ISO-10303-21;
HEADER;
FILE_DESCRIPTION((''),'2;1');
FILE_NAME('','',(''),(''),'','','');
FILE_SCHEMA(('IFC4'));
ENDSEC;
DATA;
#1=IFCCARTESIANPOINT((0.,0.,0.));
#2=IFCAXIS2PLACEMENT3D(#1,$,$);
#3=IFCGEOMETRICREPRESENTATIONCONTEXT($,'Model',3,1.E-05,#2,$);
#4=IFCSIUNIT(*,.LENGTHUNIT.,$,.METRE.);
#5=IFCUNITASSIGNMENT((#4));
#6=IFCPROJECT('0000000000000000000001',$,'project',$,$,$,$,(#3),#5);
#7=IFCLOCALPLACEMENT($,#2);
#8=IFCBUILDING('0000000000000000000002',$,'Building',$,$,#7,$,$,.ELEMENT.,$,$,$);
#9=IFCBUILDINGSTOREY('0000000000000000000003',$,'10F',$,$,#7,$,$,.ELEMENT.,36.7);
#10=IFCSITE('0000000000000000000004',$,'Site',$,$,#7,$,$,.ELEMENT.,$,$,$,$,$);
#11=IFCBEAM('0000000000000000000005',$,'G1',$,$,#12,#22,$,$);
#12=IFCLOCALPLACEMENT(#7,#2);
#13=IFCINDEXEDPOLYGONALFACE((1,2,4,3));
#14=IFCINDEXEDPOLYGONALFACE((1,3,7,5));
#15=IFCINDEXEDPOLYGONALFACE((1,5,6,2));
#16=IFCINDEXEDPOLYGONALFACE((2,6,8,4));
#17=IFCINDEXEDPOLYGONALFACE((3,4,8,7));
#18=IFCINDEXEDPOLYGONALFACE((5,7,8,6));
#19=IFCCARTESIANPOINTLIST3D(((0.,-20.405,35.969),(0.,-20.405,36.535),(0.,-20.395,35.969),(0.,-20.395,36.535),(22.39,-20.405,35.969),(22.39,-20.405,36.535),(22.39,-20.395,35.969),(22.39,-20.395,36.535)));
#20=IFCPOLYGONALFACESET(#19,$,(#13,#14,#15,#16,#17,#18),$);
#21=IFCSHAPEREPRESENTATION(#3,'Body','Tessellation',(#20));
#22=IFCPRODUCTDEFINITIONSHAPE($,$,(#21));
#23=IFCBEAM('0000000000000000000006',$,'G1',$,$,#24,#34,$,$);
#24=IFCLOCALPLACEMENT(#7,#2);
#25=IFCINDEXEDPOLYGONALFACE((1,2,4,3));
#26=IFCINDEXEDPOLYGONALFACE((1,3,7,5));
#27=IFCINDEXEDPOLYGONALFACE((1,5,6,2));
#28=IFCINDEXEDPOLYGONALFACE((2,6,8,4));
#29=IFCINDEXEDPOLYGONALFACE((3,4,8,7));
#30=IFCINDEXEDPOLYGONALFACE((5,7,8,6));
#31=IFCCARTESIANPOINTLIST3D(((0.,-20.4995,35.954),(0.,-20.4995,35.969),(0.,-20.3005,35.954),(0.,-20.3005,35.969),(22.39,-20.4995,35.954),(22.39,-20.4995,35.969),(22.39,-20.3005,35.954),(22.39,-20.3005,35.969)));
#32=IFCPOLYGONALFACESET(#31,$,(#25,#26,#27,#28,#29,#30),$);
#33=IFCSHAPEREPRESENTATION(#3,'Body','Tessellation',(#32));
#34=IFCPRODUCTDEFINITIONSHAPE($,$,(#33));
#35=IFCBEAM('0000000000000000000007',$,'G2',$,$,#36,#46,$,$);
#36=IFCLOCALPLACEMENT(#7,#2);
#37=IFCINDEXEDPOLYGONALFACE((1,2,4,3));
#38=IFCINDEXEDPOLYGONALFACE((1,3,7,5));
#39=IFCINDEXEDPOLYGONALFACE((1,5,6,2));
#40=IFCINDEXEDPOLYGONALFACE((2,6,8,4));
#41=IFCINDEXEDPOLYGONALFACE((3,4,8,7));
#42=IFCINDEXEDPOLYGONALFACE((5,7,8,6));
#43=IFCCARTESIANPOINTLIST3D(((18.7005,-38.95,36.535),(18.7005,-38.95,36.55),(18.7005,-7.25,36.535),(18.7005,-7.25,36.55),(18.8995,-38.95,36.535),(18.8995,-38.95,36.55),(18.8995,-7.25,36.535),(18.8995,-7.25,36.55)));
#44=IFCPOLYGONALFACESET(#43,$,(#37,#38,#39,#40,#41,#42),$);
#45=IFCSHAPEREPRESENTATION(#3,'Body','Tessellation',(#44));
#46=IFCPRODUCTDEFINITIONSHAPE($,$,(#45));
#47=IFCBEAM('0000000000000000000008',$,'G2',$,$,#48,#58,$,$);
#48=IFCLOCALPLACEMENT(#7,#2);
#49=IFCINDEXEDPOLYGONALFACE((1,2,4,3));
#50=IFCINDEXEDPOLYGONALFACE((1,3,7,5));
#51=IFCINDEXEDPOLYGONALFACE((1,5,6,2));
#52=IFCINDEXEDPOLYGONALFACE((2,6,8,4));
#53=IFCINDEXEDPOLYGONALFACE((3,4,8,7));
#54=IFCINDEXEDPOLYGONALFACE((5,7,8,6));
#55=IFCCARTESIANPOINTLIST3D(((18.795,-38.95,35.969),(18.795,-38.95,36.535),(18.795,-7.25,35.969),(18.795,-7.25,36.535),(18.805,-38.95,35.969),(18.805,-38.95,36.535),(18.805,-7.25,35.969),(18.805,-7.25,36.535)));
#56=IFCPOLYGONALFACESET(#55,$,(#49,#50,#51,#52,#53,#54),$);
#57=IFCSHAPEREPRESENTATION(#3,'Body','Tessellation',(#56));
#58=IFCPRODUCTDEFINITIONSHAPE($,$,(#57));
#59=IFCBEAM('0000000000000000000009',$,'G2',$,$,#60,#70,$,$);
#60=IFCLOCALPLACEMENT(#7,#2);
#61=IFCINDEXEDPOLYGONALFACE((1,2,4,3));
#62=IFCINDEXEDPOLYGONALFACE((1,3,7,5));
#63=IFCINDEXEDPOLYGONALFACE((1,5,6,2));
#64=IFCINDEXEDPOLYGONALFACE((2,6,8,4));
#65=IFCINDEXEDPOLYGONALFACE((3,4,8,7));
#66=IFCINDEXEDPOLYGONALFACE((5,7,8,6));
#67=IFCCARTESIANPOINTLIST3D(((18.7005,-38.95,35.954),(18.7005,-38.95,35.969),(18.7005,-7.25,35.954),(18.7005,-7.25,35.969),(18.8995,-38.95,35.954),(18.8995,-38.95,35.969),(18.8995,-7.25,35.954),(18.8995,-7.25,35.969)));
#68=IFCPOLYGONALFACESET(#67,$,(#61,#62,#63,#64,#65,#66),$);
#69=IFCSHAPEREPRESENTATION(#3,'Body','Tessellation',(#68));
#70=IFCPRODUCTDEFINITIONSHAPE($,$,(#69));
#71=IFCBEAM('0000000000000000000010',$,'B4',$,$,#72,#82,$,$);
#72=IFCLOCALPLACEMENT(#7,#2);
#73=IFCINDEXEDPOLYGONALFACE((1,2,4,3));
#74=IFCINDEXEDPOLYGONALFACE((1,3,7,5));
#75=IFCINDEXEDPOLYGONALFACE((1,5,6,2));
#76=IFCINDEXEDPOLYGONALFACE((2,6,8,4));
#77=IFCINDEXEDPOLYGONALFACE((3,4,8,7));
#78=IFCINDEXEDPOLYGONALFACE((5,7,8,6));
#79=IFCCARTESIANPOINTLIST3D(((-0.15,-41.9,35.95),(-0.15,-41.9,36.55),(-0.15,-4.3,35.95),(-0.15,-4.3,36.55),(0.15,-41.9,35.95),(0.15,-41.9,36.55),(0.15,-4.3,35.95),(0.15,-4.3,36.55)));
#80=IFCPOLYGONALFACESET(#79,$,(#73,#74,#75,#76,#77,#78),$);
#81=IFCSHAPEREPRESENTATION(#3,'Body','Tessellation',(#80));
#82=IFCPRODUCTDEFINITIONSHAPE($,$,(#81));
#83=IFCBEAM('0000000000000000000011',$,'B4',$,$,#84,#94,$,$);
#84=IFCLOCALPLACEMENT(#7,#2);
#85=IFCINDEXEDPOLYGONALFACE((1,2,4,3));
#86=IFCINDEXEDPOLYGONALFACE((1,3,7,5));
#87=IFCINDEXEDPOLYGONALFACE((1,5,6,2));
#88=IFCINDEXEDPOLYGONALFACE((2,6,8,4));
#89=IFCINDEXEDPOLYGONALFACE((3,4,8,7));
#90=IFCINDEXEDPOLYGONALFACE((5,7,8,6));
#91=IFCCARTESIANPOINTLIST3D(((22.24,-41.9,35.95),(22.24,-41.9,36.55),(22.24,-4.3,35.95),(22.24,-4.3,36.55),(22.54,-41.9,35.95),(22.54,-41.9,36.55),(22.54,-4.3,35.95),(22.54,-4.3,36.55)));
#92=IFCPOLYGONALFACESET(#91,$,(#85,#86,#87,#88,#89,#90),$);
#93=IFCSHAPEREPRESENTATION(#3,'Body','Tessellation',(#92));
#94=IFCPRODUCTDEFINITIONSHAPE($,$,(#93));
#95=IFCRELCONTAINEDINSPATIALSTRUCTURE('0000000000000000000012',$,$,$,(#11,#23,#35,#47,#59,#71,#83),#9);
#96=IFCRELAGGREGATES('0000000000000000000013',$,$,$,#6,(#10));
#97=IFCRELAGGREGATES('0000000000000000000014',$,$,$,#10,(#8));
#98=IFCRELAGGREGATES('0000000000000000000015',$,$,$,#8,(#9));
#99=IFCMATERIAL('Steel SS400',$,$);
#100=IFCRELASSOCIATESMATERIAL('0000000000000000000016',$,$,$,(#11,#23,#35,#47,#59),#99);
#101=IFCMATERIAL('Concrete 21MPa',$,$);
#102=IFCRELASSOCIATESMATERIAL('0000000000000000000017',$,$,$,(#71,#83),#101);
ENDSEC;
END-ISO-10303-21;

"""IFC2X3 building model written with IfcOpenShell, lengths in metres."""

from ifc_helpers import new_model, si_unit, frame, origin, origin_2d, place, context, project, spatial, rectangle, extrude, material, element, save


model = new_model("IFC2X3")

# Units and contexts
model_context = context("Model", 3, precision=1e-05, world=origin())
ifc_project = project(units=[si_unit("LENGTHUNIT", "METRE")], contexts=[model_context])

# Site, building, storey
placement = place(None, origin())
site = spatial("IfcSite", under=ifc_project, at=placement, Name="Site", CompositionType="ELEMENT")
building = spatial("IfcBuilding", under=site, at=placement, Name="Building", CompositionType="ELEMENT")
storey = spatial("IfcBuildingStorey", under=building, at=placement, Name="10F", CompositionType="ELEMENT", Elevation=36.7)

# Shared definitions
ifc_material_1 = material(Name="Concrete 21MPa")
ifc_material_2 = material(Name="Steel SS400")

# Beams
beam_1_placement = place(None, frame((11.195, -20.4, 35.969)))
element("IfcBeam", 1, at=beam_1_placement, inside=storey, material=ifc_material_2, Name="G1", context=model_context, shape_type="SweptSolid", body=[
    extrude(rectangle(XDim=22.39, YDim=0.01, at=origin_2d()), origin(), (0.0, 0.0, 1.0), 0.566),
])
beam_2_placement = place(None, frame((11.195, -20.4, 35.954)))
element("IfcBeam", 2, at=beam_2_placement, inside=storey, material=ifc_material_2, Name="G1", context=model_context, shape_type="SweptSolid", body=[
    extrude(rectangle(XDim=22.39, YDim=0.199, at=origin_2d()), origin(), (0.0, 0.0, 1.0), 0.015),
])
beam_3_placement = place(None, frame((18.8, -23.1, 36.535)))
element("IfcBeam", 3, at=beam_3_placement, inside=storey, material=ifc_material_2, Name="G2", context=model_context, shape_type="SweptSolid", body=[
    extrude(rectangle(XDim=0.199, YDim=31.7, at=origin_2d()), origin(), (0.0, 0.0, 1.0), 0.015),
])
beam_4_placement = place(None, frame((18.8, -23.1, 35.969)))
element("IfcBeam", 4, at=beam_4_placement, inside=storey, material=ifc_material_2, Name="G2", context=model_context, shape_type="SweptSolid", body=[
    extrude(rectangle(XDim=0.01, YDim=31.7, at=origin_2d()), origin(), (0.0, 0.0, 1.0), 0.566),
])
beam_5_placement = place(None, frame((18.8, -23.1, 35.954)))
element("IfcBeam", 5, at=beam_5_placement, inside=storey, material=ifc_material_2, Name="G2", context=model_context, shape_type="SweptSolid", body=[
    extrude(rectangle(XDim=0.199, YDim=31.7, at=origin_2d()), origin(), (0.0, 0.0, 1.0), 0.015),
])
for number, where, name in (
    (6, (0.0, -23.1, 35.95), "B4"),
    (7, (22.39, -23.1, 35.95), "B4"),
):
    element("IfcBeam", number, at=place(None, frame(where)), inside=storey, material=ifc_material_1, Name=name, context=model_context, shape_type="SweptSolid", body=[
        extrude(rectangle(XDim=0.3, YDim=37.6, at=origin_2d()), origin(), (0.0, 0.0, 1.0), 0.6),
    ])

save(model, "model.ifc")
